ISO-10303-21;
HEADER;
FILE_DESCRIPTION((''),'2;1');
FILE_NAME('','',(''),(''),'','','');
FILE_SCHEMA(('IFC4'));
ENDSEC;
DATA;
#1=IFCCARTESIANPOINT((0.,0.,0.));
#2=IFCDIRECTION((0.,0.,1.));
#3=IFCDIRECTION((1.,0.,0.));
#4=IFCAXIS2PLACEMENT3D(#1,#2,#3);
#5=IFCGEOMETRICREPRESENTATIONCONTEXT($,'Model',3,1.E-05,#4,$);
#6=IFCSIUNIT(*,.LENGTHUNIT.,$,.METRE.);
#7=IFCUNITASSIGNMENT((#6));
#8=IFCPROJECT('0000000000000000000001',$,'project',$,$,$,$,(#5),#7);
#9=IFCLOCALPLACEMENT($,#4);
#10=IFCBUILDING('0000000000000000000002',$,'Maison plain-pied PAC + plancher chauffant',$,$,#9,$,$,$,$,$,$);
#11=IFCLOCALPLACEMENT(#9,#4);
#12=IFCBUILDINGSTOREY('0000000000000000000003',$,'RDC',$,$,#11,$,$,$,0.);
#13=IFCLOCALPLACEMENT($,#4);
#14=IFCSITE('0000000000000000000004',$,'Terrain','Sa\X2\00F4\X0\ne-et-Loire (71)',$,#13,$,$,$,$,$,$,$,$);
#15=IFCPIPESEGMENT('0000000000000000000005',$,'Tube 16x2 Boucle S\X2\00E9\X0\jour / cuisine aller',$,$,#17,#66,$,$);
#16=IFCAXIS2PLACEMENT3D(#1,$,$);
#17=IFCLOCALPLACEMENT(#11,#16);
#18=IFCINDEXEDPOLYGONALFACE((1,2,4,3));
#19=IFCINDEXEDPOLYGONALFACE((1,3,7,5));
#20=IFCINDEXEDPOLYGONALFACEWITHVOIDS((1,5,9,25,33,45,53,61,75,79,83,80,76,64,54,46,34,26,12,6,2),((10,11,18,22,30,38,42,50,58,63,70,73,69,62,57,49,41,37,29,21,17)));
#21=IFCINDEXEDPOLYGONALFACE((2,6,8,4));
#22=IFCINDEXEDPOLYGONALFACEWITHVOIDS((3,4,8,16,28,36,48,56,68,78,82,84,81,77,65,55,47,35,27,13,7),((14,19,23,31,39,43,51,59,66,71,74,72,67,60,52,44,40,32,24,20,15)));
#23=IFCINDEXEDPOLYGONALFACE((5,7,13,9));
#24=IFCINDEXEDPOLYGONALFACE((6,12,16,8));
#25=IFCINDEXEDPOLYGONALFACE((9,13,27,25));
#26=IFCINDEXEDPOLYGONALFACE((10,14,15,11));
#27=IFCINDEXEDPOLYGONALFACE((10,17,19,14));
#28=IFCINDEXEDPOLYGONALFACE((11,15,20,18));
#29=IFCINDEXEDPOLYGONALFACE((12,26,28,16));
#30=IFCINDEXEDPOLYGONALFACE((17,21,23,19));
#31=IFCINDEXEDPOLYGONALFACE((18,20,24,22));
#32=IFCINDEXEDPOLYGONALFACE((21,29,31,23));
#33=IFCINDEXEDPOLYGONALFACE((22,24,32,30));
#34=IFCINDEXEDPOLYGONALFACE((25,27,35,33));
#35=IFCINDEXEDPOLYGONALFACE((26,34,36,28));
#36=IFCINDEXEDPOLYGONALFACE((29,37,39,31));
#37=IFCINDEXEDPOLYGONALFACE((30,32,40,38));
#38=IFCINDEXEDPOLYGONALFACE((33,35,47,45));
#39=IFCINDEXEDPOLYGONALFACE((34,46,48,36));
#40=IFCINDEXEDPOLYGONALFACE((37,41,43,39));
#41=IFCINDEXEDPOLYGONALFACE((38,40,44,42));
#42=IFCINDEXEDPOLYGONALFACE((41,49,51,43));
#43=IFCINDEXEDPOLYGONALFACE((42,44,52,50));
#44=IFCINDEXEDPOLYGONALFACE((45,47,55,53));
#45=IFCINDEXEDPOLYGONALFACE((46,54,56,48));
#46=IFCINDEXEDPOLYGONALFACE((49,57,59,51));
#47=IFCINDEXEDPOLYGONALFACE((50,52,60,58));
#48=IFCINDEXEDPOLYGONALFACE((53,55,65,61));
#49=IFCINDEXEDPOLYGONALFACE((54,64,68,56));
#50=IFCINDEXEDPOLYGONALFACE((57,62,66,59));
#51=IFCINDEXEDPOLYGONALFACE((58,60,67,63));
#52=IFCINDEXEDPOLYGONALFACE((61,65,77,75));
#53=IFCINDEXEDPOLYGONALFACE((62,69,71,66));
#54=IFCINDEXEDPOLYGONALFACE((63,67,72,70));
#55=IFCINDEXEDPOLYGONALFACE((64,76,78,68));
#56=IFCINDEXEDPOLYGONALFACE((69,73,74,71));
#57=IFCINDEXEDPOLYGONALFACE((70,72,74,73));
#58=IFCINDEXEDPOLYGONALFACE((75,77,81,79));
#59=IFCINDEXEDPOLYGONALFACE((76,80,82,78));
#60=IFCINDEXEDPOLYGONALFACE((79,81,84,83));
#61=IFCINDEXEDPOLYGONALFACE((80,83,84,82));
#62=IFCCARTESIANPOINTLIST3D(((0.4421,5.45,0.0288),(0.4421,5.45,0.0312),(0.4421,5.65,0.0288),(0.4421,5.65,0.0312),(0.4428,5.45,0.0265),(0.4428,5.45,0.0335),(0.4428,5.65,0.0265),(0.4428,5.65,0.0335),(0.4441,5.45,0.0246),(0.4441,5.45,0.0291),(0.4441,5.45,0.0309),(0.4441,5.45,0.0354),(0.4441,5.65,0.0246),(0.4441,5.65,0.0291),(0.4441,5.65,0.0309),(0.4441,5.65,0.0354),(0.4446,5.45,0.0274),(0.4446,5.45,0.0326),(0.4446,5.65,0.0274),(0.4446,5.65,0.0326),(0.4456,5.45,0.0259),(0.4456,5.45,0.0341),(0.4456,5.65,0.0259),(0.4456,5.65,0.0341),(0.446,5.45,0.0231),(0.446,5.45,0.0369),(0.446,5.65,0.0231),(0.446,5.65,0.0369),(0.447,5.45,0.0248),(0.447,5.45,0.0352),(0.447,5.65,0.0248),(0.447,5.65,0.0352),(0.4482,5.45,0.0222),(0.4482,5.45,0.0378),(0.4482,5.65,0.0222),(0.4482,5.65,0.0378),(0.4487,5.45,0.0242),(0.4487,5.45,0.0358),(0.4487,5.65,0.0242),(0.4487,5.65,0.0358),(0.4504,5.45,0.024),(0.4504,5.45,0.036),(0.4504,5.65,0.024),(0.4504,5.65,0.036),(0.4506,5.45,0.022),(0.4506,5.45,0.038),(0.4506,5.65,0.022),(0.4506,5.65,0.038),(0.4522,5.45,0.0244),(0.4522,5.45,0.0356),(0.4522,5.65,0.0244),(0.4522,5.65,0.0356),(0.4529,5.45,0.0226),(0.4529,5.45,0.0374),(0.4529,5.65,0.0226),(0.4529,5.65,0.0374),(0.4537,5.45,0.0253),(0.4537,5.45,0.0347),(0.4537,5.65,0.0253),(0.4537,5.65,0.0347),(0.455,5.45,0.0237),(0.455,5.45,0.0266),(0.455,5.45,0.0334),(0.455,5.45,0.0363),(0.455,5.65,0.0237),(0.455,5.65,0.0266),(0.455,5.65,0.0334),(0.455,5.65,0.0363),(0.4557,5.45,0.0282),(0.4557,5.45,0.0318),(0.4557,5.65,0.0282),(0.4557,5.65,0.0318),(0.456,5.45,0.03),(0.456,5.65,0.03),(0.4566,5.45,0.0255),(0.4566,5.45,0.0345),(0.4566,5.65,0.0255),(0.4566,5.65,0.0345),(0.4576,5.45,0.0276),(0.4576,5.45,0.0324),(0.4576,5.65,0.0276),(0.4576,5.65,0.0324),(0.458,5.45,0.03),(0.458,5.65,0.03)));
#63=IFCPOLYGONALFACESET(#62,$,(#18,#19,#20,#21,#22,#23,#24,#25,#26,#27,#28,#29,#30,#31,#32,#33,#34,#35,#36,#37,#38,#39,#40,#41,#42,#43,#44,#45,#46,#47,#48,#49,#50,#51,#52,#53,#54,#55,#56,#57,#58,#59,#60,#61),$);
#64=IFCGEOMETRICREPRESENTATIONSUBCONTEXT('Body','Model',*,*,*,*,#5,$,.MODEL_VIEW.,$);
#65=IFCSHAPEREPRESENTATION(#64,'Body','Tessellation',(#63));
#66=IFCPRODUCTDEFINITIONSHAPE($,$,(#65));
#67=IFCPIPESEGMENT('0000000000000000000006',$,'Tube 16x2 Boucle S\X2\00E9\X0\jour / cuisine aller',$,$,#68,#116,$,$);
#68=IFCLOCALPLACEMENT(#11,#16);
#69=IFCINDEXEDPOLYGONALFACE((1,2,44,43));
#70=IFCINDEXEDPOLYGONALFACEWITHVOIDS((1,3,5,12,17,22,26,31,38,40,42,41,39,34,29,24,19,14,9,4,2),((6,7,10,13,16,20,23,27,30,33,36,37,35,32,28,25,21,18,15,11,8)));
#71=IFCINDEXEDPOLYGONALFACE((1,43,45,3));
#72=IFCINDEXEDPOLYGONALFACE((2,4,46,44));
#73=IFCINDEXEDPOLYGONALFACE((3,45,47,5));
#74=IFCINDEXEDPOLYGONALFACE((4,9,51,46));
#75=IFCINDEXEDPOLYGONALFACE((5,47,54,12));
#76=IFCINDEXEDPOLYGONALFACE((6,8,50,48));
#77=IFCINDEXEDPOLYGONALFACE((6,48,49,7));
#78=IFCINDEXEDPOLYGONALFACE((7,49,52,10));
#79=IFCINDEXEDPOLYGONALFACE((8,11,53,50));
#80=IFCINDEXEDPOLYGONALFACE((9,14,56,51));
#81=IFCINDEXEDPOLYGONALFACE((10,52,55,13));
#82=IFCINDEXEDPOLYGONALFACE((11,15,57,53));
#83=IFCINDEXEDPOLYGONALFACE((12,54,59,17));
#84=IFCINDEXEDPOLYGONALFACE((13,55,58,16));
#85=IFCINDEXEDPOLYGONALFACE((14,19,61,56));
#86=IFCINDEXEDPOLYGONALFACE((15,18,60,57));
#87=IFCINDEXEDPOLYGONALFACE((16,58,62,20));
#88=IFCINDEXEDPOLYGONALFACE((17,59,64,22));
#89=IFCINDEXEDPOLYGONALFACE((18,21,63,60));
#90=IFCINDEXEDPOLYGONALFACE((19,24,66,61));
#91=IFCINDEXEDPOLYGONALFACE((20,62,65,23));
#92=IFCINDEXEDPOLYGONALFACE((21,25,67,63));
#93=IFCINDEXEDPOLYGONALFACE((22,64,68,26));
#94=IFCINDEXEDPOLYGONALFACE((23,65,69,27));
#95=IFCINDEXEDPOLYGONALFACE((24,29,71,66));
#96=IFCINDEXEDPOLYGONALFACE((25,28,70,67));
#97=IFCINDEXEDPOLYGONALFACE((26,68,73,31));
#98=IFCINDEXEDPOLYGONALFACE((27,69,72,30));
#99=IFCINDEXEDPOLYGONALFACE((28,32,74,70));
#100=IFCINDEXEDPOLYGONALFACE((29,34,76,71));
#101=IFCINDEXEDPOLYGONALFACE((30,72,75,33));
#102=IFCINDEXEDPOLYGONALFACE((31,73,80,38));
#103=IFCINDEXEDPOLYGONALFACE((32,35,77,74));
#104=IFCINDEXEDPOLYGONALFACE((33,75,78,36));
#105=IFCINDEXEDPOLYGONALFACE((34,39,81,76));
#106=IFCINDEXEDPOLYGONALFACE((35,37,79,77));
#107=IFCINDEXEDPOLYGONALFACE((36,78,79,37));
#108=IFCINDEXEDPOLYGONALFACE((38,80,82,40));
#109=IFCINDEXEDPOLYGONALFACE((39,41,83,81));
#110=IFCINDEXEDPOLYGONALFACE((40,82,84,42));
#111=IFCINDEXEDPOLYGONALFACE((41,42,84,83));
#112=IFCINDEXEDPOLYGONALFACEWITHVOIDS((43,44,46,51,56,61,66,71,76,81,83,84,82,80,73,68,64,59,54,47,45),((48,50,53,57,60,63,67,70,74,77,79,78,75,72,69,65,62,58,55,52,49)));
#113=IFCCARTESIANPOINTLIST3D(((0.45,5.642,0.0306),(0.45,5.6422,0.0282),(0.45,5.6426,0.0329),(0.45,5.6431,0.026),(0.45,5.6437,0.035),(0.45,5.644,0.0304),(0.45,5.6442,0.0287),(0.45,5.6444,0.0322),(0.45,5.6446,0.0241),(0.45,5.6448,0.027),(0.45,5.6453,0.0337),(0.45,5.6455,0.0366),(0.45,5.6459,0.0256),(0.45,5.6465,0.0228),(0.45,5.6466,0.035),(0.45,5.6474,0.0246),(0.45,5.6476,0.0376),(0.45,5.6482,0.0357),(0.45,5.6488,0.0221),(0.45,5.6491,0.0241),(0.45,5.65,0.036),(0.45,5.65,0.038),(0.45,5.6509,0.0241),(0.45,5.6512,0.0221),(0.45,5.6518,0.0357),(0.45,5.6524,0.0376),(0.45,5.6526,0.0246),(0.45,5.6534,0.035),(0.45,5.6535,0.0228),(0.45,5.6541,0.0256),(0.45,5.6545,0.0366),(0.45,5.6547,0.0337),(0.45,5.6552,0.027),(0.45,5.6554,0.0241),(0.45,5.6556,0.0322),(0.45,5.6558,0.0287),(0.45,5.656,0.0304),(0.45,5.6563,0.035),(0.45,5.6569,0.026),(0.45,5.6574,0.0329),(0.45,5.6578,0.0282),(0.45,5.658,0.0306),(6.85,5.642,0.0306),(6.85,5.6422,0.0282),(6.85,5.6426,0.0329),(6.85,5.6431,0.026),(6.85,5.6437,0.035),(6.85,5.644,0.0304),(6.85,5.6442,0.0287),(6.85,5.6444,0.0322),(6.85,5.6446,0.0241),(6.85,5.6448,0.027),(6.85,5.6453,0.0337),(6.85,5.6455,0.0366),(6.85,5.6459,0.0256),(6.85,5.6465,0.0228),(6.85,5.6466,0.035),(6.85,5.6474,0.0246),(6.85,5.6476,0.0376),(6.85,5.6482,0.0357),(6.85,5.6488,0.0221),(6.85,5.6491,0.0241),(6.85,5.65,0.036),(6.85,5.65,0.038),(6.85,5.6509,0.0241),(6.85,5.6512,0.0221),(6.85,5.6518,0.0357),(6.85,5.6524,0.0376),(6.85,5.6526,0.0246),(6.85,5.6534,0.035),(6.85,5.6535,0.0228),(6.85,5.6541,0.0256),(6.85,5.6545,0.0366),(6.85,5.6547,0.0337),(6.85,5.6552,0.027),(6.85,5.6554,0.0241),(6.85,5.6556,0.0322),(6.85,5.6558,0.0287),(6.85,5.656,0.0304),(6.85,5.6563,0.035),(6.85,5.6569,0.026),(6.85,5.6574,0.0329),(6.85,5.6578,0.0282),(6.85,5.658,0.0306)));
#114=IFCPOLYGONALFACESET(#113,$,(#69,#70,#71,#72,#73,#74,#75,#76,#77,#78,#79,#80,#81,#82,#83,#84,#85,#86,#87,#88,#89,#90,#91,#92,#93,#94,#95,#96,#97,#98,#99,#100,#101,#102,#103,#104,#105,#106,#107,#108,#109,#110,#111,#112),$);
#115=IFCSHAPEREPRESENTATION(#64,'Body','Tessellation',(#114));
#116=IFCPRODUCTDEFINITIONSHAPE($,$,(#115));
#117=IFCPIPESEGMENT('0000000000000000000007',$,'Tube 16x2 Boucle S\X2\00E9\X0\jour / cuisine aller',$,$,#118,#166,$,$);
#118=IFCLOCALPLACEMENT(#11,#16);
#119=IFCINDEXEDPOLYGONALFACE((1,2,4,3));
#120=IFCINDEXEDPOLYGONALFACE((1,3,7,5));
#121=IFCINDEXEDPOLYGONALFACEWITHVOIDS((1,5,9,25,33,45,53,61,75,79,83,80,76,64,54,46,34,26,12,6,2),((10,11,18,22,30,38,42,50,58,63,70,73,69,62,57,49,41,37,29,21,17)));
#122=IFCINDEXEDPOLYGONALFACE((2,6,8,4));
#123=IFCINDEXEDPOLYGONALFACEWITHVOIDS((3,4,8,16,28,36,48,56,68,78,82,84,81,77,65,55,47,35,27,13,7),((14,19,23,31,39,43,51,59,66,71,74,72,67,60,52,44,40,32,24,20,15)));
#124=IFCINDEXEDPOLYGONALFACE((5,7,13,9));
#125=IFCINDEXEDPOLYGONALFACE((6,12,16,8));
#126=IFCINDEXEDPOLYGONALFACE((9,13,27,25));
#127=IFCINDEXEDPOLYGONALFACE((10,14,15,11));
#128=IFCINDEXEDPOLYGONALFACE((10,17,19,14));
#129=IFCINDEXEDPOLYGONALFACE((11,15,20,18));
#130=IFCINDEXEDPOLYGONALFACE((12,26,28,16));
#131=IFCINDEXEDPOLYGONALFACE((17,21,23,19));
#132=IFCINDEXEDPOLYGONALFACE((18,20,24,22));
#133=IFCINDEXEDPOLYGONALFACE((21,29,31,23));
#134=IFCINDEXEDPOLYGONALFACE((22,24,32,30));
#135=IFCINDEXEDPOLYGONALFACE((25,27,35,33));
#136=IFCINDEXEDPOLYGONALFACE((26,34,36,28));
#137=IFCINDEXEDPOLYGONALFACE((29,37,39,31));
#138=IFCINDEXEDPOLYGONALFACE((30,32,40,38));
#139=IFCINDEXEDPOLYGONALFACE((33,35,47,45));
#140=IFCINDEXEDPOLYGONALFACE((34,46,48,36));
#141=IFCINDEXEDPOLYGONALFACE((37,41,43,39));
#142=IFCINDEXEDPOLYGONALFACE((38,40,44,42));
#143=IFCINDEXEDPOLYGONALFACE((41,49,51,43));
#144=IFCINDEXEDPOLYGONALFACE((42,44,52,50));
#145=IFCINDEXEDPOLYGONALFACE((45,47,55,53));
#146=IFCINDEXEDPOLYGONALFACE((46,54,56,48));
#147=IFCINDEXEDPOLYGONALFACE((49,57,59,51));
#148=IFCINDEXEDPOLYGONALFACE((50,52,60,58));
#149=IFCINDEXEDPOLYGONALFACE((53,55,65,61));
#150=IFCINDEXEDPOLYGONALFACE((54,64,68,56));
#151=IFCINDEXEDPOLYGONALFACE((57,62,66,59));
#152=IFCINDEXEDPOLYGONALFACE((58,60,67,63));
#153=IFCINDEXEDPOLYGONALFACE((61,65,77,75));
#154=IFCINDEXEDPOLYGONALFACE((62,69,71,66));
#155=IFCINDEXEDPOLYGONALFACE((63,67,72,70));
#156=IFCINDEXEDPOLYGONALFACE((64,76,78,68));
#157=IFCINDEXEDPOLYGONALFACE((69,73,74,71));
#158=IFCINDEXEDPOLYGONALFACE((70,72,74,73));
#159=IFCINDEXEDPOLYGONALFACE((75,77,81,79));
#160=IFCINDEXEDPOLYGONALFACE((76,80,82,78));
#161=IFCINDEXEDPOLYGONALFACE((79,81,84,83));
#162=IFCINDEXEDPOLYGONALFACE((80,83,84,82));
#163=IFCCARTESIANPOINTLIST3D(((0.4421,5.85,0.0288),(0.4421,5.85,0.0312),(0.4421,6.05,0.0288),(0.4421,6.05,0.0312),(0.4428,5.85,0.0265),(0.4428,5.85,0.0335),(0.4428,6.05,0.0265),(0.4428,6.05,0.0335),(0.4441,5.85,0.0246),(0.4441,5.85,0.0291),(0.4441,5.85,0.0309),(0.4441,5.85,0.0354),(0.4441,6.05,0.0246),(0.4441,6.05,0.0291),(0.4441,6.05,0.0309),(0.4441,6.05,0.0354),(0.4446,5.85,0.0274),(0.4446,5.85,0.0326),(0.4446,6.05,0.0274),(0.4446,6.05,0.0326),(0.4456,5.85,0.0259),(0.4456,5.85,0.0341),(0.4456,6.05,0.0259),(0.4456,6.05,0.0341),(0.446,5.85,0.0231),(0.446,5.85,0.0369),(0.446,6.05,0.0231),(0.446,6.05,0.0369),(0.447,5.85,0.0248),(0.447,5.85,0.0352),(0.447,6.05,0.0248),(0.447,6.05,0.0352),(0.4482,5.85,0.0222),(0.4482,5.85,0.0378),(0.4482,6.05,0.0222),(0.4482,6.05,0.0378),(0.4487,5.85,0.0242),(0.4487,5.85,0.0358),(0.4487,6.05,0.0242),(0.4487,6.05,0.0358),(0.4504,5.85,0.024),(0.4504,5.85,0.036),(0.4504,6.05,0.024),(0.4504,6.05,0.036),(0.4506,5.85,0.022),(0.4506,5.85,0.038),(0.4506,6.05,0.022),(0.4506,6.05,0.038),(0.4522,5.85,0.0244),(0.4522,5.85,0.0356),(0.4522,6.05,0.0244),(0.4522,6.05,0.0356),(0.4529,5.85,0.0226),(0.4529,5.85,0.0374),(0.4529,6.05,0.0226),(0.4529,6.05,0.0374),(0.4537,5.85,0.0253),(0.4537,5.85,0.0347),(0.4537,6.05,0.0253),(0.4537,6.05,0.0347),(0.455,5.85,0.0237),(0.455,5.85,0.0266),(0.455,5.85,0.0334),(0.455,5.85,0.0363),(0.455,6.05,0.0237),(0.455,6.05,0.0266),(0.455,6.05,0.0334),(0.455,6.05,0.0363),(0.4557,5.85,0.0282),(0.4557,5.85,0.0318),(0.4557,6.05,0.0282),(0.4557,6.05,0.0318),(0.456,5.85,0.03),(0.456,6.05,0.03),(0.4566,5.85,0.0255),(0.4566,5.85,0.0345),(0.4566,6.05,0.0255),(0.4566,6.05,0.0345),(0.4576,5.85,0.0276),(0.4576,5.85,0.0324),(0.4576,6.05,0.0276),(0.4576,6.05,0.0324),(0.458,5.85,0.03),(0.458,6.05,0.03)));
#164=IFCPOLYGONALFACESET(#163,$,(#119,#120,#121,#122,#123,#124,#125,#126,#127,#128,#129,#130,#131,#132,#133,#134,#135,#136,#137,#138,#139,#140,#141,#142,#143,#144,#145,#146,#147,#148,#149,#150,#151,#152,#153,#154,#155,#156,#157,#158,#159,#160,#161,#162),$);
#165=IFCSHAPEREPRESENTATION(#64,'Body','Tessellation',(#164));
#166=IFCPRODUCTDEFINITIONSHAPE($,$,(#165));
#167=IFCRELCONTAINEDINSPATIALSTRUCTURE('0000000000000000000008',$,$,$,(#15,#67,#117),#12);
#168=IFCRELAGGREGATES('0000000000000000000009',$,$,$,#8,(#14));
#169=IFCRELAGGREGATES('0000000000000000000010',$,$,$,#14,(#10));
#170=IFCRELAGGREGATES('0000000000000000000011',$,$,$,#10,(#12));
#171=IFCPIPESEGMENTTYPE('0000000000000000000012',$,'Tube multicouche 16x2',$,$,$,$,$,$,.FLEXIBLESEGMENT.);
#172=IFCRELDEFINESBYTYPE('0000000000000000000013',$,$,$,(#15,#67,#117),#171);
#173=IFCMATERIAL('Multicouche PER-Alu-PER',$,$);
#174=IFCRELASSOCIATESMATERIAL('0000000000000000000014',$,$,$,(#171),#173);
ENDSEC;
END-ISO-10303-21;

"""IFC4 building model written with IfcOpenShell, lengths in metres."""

from ifc_helpers import new_model, si_unit, frame, origin_with_axes, place, context, subcontext, project, spatial, hollow_circle, extrude, material, type_object, element, save


model = new_model("IFC4")

# Units and contexts
model_context = context("Model", 3, precision=1e-05, world=origin_with_axes())
body_context = subcontext(model_context, "Body", "Model", "MODEL_VIEW")
ifc_project = project(units=[si_unit("LENGTHUNIT", "METRE")], contexts=[model_context])

# Site, building, storey
site_placement = place(None, origin_with_axes())
site = spatial("IfcSite", under=ifc_project, at=site_placement, Name="Terrain", Description="Saône-et-Loire (71)")
building_placement = place(None, origin_with_axes())
building = spatial("IfcBuilding", under=site, at=building_placement, Name="Maison plain-pied PAC + plancher chauffant")
storey_placement = place(building_placement, origin_with_axes())
storey = spatial("IfcBuildingStorey", under=building, at=storey_placement, Name="RDC", Elevation=0.0)

# Pipe segments
ifc_material_1 = material(Name="Multicouche PER-Alu-PER")
pipe_segment_type_1 = type_object("IfcPipeSegmentType", Name="Tube multicouche 16x2", PredefinedType="FLEXIBLESEGMENT", material=ifc_material_1)
pipe_segment_1_placement = place(storey_placement, frame((0.45, 5.45, 0.03), z_axis=(0.0, 1.0, 0.0), x_axis=(1.0, 0.0, 0.0)))
element("IfcPipeSegment", 1, at=pipe_segment_1_placement, inside=storey, type_object=pipe_segment_type_1, Name="Tube 16x2 Boucle Séjour / cuisine aller", context=body_context, shape_type="SweptSolid", body=[
    extrude(hollow_circle(Radius=0.008, WallThickness=0.002), origin_with_axes(), (0.0, 0.0, 1.0), 0.2),
])
pipe_segment_2_placement = place(storey_placement, frame((0.45, 5.65, 0.03), z_axis=(1.0, 0.0, 0.0), x_axis=(0.0, 0.0, 1.0)))
element("IfcPipeSegment", 2, at=pipe_segment_2_placement, inside=storey, type_object=pipe_segment_type_1, Name="Tube 16x2 Boucle Séjour / cuisine aller", context=body_context, shape_type="SweptSolid", body=[
    extrude(hollow_circle(Radius=0.008, WallThickness=0.002), origin_with_axes(), (0.0, 0.0, 1.0), 6.4),
])
pipe_segment_3_placement = place(storey_placement, frame((0.45, 5.85, 0.03), z_axis=(0.0, 1.0, 0.0), x_axis=(1.0, 0.0, 0.0)))
element("IfcPipeSegment", 3, at=pipe_segment_3_placement, inside=storey, type_object=pipe_segment_type_1, Name="Tube 16x2 Boucle Séjour / cuisine aller", context=body_context, shape_type="SweptSolid", body=[
    extrude(hollow_circle(Radius=0.008, WallThickness=0.002), origin_with_axes(), (0.0, 0.0, 1.0), 0.2),
])

save(model, "model.ifc")
